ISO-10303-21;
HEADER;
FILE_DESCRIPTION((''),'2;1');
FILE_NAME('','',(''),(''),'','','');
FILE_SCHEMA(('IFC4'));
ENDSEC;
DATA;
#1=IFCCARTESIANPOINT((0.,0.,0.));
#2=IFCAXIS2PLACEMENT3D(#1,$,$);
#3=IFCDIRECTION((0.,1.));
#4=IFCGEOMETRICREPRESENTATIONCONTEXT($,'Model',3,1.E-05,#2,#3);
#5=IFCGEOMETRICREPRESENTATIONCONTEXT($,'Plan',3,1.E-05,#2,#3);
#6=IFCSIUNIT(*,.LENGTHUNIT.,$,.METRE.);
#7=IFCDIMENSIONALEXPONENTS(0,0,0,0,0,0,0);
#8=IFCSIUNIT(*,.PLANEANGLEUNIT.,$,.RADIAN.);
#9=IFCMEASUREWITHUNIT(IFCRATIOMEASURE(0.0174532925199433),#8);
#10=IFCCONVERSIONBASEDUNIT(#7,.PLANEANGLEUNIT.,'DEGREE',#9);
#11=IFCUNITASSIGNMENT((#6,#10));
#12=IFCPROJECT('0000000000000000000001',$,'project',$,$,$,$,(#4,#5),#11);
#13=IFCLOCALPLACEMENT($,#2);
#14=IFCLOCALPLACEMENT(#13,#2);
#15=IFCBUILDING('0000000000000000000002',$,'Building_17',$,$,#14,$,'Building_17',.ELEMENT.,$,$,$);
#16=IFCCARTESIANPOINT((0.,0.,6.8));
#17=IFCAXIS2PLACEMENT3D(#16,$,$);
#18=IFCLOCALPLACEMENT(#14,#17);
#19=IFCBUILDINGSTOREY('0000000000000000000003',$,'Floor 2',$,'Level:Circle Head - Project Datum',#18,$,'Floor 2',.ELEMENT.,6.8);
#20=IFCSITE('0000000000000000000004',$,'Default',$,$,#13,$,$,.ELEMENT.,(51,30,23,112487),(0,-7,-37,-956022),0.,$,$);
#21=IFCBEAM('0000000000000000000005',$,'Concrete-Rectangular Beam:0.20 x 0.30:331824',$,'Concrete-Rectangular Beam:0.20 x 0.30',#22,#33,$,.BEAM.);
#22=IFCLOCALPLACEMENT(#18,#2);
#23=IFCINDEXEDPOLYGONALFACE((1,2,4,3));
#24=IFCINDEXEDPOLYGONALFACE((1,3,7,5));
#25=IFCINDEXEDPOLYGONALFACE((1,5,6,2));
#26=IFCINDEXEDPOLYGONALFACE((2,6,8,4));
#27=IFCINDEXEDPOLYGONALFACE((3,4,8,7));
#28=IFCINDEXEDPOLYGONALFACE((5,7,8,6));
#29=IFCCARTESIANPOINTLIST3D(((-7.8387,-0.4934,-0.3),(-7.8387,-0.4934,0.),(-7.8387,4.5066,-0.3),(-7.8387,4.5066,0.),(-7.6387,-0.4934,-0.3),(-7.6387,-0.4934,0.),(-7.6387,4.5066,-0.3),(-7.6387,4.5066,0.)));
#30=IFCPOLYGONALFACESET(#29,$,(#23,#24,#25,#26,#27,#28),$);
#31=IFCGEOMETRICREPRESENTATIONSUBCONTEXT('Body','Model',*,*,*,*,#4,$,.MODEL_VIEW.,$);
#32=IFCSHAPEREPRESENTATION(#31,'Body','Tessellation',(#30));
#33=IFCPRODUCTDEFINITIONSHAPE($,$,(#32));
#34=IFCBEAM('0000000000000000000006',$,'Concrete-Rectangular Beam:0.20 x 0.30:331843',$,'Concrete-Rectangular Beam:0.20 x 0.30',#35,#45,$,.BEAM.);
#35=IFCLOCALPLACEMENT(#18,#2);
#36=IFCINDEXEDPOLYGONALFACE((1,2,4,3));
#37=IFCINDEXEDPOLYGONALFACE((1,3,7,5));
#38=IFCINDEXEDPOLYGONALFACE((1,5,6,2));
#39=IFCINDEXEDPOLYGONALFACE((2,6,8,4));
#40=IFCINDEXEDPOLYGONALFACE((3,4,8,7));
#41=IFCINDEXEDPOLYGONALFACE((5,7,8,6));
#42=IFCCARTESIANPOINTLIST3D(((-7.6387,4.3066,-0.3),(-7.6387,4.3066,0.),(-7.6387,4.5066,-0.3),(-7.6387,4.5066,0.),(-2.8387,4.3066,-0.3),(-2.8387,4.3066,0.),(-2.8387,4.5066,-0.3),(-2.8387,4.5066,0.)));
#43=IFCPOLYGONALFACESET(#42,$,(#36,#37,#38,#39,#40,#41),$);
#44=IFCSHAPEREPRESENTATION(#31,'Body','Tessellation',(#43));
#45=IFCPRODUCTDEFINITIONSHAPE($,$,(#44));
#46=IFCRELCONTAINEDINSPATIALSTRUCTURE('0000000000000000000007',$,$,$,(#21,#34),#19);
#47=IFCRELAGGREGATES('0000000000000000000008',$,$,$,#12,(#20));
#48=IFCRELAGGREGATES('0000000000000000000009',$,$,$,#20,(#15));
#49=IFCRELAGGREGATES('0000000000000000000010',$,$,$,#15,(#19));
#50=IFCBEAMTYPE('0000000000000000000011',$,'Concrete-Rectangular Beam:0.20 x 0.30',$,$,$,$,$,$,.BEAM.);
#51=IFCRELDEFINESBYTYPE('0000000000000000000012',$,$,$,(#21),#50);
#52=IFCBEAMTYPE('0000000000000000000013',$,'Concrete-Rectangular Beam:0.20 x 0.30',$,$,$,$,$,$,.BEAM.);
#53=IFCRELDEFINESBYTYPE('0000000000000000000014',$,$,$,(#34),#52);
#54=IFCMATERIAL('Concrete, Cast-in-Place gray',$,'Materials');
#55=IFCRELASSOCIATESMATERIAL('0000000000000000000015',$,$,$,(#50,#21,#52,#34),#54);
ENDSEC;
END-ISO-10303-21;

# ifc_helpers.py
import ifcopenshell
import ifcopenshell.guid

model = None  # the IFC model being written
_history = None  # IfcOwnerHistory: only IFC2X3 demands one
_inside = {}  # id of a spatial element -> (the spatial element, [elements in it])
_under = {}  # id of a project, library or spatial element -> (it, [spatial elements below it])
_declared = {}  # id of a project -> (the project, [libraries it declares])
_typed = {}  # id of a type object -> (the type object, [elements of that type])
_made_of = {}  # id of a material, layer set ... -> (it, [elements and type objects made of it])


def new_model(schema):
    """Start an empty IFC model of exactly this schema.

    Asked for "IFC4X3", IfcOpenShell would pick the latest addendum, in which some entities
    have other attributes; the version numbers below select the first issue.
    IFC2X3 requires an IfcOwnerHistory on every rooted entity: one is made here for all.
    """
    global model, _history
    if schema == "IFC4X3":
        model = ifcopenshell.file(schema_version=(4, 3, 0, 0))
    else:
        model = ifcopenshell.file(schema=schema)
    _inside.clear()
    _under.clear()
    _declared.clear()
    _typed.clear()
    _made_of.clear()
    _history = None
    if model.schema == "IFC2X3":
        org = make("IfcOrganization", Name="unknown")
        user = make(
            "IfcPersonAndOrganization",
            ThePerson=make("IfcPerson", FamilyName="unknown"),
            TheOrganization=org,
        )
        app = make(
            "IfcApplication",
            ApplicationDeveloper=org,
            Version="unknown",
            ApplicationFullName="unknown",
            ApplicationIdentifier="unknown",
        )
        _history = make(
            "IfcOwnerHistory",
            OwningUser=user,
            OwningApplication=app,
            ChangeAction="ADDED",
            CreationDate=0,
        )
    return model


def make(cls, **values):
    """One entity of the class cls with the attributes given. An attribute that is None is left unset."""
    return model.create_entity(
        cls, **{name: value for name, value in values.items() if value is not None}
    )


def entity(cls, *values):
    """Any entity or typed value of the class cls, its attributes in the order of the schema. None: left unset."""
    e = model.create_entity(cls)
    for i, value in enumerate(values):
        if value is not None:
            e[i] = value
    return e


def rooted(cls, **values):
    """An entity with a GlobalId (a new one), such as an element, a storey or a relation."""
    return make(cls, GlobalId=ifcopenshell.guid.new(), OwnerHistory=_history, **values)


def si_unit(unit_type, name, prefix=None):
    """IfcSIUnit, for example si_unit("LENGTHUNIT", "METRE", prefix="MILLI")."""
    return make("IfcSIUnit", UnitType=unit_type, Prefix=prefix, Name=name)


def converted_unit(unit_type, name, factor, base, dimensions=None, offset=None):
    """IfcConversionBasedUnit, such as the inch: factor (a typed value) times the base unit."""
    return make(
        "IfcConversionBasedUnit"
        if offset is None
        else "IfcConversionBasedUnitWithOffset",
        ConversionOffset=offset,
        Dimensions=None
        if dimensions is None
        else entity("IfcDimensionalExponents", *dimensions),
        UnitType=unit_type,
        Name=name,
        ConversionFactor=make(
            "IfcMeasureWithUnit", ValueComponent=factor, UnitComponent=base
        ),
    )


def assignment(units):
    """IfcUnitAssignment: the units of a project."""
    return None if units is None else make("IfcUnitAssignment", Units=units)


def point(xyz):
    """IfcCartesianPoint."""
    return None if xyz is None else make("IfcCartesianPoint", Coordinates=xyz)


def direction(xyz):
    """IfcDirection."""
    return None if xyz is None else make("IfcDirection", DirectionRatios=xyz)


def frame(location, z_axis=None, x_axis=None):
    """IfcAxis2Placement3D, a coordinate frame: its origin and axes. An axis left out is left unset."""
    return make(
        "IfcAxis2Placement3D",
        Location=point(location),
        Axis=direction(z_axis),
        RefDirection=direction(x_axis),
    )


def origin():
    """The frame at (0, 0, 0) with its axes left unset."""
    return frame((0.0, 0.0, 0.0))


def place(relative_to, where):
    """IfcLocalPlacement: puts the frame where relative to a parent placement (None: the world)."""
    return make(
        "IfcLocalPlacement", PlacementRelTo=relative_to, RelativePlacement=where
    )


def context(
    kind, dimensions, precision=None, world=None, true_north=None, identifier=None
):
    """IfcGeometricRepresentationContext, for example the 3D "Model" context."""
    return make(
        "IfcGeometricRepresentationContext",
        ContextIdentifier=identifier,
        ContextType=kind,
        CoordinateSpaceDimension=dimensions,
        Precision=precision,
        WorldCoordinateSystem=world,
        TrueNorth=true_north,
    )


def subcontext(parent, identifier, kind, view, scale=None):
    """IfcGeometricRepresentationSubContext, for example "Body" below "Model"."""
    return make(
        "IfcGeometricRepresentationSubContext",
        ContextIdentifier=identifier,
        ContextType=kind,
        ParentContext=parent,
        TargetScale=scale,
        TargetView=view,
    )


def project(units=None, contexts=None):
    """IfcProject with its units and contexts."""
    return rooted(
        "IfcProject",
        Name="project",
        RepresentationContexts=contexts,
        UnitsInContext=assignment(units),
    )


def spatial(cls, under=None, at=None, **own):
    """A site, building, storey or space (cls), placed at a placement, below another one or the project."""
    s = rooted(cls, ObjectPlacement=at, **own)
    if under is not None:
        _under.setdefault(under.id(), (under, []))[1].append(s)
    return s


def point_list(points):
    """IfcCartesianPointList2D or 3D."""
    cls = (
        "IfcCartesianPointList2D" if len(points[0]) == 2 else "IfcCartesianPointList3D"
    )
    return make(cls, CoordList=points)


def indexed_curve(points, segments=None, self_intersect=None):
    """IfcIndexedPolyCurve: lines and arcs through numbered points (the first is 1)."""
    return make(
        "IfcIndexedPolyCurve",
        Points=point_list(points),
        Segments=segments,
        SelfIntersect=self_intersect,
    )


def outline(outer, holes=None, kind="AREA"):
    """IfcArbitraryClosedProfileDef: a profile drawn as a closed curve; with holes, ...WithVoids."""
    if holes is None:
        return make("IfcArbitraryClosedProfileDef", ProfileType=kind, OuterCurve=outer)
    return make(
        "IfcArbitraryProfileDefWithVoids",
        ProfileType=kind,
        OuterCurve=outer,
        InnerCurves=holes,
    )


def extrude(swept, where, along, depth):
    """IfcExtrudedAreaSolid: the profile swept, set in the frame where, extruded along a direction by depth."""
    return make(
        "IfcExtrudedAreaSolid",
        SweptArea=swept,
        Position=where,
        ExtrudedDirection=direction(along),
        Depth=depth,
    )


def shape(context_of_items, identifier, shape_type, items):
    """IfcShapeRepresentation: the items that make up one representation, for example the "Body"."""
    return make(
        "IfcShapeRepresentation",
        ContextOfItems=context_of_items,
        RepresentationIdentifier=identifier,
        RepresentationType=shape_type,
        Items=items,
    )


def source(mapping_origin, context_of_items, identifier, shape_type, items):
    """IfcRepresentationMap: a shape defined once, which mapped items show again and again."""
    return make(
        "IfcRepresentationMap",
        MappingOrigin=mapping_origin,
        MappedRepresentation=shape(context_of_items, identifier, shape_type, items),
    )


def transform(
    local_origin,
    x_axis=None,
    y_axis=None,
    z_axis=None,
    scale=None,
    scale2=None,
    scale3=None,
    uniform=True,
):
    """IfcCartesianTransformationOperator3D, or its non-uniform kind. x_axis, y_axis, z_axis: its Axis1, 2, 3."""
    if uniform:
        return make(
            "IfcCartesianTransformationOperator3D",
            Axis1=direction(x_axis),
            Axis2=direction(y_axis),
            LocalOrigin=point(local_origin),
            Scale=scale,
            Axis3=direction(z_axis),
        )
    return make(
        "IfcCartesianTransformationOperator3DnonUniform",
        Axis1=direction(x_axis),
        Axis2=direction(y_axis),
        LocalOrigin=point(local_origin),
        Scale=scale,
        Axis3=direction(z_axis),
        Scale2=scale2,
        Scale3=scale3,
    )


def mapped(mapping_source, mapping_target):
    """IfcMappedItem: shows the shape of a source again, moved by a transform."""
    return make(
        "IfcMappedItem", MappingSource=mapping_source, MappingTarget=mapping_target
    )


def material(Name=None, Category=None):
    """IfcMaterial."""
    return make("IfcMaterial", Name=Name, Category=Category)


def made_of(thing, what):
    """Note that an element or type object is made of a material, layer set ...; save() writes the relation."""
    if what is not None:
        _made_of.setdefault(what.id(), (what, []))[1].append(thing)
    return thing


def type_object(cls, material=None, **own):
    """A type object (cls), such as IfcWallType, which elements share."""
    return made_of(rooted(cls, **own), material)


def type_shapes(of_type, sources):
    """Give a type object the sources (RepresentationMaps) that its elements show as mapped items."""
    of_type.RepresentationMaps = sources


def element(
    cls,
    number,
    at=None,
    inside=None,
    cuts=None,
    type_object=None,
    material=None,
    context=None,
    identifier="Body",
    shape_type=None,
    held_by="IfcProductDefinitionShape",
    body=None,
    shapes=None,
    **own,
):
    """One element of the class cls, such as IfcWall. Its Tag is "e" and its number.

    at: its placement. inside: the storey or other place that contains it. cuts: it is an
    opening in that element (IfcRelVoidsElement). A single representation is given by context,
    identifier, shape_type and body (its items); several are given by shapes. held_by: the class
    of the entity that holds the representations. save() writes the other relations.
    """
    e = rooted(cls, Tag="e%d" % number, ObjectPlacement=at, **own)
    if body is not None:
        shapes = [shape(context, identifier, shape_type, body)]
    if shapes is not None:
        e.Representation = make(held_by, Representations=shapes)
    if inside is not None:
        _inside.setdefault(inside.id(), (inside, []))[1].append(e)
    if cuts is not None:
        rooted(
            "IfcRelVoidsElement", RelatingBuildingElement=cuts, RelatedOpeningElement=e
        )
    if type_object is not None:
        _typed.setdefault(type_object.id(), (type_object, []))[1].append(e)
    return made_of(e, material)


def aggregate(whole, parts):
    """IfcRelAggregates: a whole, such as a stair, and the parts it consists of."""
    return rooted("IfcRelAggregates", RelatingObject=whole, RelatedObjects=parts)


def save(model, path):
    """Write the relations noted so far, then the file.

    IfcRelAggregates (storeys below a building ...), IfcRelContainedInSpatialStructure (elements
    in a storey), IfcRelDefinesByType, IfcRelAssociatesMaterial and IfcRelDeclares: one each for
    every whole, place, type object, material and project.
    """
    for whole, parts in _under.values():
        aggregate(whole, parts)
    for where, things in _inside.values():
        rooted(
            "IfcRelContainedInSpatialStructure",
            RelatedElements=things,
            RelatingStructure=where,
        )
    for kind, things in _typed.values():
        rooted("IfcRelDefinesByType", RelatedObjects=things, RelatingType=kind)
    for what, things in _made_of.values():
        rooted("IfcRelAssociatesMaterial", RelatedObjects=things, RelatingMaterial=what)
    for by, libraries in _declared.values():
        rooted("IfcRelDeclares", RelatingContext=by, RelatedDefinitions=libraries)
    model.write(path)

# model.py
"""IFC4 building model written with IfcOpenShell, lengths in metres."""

from ifc_helpers import new_model, entity, si_unit, converted_unit, direction, frame, origin, place, context, subcontext, project, spatial, indexed_curve, outline, extrude, source, transform, mapped, material, type_object, type_shapes, element, save


model = new_model("IFC4")

# Units and contexts
model_context = context("Model", 3, precision=1e-05, world=origin(), true_north=direction((0.0, 1.0)))
plan_context = context("Plan", 3, precision=1e-05, world=origin(), true_north=direction((0.0, 1.0)))
body_context = subcontext(model_context, "Body", "Model", "MODEL_VIEW")
ifc_project = project(units=[si_unit("LENGTHUNIT", "METRE"), converted_unit("PLANEANGLEUNIT", "DEGREE", entity("IfcRatioMeasure", 0.0174532925199433), si_unit("PLANEANGLEUNIT", "RADIAN"), dimensions=[0, 0, 0, 0, 0, 0, 0])], contexts=[model_context, plan_context])

# Site, building, storey
site_placement = place(None, origin())
site = spatial("IfcSite", under=ifc_project, at=site_placement, Name="Default", CompositionType="ELEMENT", RefLatitude=(51, 30, 23, 112487), RefLongitude=(0, -7, -37, -956022), RefElevation=0.0)
building_placement = place(site_placement, origin())
building = spatial("IfcBuilding", under=site, at=building_placement, Name="Building_17", LongName="Building_17", CompositionType="ELEMENT")
storey_placement = place(building_placement, frame((0.0, 0.0, 6.8)))
storey = spatial("IfcBuildingStorey", under=building, at=storey_placement, Name="Floor 2", ObjectType="Level:Circle Head - Project Datum", LongName="Floor 2", CompositionType="ELEMENT", Elevation=6.8)

# Beams
ifc_material = material(Name="Concrete, Cast-in-Place gray", Category="Materials")
beam_type_1 = type_object("IfcBeamType", Name="Concrete-Rectangular Beam:0.20 x 0.30", PredefinedType="BEAM", material=ifc_material)
shared_shape_1 = source(origin(), body_context, "Body", "SweptSolid", [
    extrude(outline(indexed_curve([(-0.1, -0.15), (0.1, -0.15), (0.1, 0.15), (-0.1, 0.15), (-0.1, -0.15)], self_intersect=False)), frame((-7.7387, -0.4934, 6.65), z_axis=(0.0, 1.0, 0.0), x_axis=(-1.0, 0.0, 0.0)), (0.0, 0.0, 1.0), 5.0),
])
type_shapes(beam_type_1, [shared_shape_1])
beam_1_placement = place(storey_placement, frame((0.0, 0.0, -6.8)))
element("IfcBeam", 1, at=beam_1_placement, inside=storey, type_object=beam_type_1, material=ifc_material, Name="Concrete-Rectangular Beam:0.20 x 0.30:331824", ObjectType="Concrete-Rectangular Beam:0.20 x 0.30", PredefinedType="BEAM", context=body_context, shape_type="MappedRepresentation", body=[
    mapped(shared_shape_1, transform((0.0, 0.0, 0.0), scale=1.0)),
])
beam_type_2 = type_object("IfcBeamType", Name="Concrete-Rectangular Beam:0.20 x 0.30", PredefinedType="BEAM", material=ifc_material)
shared_shape_2 = source(origin(), body_context, "Body", "SweptSolid", [
    extrude(outline(indexed_curve([(-0.15, -0.1), (0.15, -0.1), (0.15, 0.1), (-0.15, 0.1), (-0.15, -0.1)], self_intersect=False)), frame((-7.6387, 4.4066, 6.65), z_axis=(1.0, 0.0, 0.0), x_axis=(0.0, 0.0, -1.0)), (0.0, 0.0, 1.0), 4.8),
])
type_shapes(beam_type_2, [shared_shape_2])
beam_2_placement = place(storey_placement, frame((0.0, 0.0, -6.8)))
element("IfcBeam", 2, at=beam_2_placement, inside=storey, type_object=beam_type_2, material=ifc_material, Name="Concrete-Rectangular Beam:0.20 x 0.30:331843", ObjectType="Concrete-Rectangular Beam:0.20 x 0.30", PredefinedType="BEAM", context=body_context, shape_type="MappedRepresentation", body=[
    mapped(shared_shape_2, transform((0.0, 0.0, 0.0), scale=1.0)),
])

save(model, "model.ifc")
